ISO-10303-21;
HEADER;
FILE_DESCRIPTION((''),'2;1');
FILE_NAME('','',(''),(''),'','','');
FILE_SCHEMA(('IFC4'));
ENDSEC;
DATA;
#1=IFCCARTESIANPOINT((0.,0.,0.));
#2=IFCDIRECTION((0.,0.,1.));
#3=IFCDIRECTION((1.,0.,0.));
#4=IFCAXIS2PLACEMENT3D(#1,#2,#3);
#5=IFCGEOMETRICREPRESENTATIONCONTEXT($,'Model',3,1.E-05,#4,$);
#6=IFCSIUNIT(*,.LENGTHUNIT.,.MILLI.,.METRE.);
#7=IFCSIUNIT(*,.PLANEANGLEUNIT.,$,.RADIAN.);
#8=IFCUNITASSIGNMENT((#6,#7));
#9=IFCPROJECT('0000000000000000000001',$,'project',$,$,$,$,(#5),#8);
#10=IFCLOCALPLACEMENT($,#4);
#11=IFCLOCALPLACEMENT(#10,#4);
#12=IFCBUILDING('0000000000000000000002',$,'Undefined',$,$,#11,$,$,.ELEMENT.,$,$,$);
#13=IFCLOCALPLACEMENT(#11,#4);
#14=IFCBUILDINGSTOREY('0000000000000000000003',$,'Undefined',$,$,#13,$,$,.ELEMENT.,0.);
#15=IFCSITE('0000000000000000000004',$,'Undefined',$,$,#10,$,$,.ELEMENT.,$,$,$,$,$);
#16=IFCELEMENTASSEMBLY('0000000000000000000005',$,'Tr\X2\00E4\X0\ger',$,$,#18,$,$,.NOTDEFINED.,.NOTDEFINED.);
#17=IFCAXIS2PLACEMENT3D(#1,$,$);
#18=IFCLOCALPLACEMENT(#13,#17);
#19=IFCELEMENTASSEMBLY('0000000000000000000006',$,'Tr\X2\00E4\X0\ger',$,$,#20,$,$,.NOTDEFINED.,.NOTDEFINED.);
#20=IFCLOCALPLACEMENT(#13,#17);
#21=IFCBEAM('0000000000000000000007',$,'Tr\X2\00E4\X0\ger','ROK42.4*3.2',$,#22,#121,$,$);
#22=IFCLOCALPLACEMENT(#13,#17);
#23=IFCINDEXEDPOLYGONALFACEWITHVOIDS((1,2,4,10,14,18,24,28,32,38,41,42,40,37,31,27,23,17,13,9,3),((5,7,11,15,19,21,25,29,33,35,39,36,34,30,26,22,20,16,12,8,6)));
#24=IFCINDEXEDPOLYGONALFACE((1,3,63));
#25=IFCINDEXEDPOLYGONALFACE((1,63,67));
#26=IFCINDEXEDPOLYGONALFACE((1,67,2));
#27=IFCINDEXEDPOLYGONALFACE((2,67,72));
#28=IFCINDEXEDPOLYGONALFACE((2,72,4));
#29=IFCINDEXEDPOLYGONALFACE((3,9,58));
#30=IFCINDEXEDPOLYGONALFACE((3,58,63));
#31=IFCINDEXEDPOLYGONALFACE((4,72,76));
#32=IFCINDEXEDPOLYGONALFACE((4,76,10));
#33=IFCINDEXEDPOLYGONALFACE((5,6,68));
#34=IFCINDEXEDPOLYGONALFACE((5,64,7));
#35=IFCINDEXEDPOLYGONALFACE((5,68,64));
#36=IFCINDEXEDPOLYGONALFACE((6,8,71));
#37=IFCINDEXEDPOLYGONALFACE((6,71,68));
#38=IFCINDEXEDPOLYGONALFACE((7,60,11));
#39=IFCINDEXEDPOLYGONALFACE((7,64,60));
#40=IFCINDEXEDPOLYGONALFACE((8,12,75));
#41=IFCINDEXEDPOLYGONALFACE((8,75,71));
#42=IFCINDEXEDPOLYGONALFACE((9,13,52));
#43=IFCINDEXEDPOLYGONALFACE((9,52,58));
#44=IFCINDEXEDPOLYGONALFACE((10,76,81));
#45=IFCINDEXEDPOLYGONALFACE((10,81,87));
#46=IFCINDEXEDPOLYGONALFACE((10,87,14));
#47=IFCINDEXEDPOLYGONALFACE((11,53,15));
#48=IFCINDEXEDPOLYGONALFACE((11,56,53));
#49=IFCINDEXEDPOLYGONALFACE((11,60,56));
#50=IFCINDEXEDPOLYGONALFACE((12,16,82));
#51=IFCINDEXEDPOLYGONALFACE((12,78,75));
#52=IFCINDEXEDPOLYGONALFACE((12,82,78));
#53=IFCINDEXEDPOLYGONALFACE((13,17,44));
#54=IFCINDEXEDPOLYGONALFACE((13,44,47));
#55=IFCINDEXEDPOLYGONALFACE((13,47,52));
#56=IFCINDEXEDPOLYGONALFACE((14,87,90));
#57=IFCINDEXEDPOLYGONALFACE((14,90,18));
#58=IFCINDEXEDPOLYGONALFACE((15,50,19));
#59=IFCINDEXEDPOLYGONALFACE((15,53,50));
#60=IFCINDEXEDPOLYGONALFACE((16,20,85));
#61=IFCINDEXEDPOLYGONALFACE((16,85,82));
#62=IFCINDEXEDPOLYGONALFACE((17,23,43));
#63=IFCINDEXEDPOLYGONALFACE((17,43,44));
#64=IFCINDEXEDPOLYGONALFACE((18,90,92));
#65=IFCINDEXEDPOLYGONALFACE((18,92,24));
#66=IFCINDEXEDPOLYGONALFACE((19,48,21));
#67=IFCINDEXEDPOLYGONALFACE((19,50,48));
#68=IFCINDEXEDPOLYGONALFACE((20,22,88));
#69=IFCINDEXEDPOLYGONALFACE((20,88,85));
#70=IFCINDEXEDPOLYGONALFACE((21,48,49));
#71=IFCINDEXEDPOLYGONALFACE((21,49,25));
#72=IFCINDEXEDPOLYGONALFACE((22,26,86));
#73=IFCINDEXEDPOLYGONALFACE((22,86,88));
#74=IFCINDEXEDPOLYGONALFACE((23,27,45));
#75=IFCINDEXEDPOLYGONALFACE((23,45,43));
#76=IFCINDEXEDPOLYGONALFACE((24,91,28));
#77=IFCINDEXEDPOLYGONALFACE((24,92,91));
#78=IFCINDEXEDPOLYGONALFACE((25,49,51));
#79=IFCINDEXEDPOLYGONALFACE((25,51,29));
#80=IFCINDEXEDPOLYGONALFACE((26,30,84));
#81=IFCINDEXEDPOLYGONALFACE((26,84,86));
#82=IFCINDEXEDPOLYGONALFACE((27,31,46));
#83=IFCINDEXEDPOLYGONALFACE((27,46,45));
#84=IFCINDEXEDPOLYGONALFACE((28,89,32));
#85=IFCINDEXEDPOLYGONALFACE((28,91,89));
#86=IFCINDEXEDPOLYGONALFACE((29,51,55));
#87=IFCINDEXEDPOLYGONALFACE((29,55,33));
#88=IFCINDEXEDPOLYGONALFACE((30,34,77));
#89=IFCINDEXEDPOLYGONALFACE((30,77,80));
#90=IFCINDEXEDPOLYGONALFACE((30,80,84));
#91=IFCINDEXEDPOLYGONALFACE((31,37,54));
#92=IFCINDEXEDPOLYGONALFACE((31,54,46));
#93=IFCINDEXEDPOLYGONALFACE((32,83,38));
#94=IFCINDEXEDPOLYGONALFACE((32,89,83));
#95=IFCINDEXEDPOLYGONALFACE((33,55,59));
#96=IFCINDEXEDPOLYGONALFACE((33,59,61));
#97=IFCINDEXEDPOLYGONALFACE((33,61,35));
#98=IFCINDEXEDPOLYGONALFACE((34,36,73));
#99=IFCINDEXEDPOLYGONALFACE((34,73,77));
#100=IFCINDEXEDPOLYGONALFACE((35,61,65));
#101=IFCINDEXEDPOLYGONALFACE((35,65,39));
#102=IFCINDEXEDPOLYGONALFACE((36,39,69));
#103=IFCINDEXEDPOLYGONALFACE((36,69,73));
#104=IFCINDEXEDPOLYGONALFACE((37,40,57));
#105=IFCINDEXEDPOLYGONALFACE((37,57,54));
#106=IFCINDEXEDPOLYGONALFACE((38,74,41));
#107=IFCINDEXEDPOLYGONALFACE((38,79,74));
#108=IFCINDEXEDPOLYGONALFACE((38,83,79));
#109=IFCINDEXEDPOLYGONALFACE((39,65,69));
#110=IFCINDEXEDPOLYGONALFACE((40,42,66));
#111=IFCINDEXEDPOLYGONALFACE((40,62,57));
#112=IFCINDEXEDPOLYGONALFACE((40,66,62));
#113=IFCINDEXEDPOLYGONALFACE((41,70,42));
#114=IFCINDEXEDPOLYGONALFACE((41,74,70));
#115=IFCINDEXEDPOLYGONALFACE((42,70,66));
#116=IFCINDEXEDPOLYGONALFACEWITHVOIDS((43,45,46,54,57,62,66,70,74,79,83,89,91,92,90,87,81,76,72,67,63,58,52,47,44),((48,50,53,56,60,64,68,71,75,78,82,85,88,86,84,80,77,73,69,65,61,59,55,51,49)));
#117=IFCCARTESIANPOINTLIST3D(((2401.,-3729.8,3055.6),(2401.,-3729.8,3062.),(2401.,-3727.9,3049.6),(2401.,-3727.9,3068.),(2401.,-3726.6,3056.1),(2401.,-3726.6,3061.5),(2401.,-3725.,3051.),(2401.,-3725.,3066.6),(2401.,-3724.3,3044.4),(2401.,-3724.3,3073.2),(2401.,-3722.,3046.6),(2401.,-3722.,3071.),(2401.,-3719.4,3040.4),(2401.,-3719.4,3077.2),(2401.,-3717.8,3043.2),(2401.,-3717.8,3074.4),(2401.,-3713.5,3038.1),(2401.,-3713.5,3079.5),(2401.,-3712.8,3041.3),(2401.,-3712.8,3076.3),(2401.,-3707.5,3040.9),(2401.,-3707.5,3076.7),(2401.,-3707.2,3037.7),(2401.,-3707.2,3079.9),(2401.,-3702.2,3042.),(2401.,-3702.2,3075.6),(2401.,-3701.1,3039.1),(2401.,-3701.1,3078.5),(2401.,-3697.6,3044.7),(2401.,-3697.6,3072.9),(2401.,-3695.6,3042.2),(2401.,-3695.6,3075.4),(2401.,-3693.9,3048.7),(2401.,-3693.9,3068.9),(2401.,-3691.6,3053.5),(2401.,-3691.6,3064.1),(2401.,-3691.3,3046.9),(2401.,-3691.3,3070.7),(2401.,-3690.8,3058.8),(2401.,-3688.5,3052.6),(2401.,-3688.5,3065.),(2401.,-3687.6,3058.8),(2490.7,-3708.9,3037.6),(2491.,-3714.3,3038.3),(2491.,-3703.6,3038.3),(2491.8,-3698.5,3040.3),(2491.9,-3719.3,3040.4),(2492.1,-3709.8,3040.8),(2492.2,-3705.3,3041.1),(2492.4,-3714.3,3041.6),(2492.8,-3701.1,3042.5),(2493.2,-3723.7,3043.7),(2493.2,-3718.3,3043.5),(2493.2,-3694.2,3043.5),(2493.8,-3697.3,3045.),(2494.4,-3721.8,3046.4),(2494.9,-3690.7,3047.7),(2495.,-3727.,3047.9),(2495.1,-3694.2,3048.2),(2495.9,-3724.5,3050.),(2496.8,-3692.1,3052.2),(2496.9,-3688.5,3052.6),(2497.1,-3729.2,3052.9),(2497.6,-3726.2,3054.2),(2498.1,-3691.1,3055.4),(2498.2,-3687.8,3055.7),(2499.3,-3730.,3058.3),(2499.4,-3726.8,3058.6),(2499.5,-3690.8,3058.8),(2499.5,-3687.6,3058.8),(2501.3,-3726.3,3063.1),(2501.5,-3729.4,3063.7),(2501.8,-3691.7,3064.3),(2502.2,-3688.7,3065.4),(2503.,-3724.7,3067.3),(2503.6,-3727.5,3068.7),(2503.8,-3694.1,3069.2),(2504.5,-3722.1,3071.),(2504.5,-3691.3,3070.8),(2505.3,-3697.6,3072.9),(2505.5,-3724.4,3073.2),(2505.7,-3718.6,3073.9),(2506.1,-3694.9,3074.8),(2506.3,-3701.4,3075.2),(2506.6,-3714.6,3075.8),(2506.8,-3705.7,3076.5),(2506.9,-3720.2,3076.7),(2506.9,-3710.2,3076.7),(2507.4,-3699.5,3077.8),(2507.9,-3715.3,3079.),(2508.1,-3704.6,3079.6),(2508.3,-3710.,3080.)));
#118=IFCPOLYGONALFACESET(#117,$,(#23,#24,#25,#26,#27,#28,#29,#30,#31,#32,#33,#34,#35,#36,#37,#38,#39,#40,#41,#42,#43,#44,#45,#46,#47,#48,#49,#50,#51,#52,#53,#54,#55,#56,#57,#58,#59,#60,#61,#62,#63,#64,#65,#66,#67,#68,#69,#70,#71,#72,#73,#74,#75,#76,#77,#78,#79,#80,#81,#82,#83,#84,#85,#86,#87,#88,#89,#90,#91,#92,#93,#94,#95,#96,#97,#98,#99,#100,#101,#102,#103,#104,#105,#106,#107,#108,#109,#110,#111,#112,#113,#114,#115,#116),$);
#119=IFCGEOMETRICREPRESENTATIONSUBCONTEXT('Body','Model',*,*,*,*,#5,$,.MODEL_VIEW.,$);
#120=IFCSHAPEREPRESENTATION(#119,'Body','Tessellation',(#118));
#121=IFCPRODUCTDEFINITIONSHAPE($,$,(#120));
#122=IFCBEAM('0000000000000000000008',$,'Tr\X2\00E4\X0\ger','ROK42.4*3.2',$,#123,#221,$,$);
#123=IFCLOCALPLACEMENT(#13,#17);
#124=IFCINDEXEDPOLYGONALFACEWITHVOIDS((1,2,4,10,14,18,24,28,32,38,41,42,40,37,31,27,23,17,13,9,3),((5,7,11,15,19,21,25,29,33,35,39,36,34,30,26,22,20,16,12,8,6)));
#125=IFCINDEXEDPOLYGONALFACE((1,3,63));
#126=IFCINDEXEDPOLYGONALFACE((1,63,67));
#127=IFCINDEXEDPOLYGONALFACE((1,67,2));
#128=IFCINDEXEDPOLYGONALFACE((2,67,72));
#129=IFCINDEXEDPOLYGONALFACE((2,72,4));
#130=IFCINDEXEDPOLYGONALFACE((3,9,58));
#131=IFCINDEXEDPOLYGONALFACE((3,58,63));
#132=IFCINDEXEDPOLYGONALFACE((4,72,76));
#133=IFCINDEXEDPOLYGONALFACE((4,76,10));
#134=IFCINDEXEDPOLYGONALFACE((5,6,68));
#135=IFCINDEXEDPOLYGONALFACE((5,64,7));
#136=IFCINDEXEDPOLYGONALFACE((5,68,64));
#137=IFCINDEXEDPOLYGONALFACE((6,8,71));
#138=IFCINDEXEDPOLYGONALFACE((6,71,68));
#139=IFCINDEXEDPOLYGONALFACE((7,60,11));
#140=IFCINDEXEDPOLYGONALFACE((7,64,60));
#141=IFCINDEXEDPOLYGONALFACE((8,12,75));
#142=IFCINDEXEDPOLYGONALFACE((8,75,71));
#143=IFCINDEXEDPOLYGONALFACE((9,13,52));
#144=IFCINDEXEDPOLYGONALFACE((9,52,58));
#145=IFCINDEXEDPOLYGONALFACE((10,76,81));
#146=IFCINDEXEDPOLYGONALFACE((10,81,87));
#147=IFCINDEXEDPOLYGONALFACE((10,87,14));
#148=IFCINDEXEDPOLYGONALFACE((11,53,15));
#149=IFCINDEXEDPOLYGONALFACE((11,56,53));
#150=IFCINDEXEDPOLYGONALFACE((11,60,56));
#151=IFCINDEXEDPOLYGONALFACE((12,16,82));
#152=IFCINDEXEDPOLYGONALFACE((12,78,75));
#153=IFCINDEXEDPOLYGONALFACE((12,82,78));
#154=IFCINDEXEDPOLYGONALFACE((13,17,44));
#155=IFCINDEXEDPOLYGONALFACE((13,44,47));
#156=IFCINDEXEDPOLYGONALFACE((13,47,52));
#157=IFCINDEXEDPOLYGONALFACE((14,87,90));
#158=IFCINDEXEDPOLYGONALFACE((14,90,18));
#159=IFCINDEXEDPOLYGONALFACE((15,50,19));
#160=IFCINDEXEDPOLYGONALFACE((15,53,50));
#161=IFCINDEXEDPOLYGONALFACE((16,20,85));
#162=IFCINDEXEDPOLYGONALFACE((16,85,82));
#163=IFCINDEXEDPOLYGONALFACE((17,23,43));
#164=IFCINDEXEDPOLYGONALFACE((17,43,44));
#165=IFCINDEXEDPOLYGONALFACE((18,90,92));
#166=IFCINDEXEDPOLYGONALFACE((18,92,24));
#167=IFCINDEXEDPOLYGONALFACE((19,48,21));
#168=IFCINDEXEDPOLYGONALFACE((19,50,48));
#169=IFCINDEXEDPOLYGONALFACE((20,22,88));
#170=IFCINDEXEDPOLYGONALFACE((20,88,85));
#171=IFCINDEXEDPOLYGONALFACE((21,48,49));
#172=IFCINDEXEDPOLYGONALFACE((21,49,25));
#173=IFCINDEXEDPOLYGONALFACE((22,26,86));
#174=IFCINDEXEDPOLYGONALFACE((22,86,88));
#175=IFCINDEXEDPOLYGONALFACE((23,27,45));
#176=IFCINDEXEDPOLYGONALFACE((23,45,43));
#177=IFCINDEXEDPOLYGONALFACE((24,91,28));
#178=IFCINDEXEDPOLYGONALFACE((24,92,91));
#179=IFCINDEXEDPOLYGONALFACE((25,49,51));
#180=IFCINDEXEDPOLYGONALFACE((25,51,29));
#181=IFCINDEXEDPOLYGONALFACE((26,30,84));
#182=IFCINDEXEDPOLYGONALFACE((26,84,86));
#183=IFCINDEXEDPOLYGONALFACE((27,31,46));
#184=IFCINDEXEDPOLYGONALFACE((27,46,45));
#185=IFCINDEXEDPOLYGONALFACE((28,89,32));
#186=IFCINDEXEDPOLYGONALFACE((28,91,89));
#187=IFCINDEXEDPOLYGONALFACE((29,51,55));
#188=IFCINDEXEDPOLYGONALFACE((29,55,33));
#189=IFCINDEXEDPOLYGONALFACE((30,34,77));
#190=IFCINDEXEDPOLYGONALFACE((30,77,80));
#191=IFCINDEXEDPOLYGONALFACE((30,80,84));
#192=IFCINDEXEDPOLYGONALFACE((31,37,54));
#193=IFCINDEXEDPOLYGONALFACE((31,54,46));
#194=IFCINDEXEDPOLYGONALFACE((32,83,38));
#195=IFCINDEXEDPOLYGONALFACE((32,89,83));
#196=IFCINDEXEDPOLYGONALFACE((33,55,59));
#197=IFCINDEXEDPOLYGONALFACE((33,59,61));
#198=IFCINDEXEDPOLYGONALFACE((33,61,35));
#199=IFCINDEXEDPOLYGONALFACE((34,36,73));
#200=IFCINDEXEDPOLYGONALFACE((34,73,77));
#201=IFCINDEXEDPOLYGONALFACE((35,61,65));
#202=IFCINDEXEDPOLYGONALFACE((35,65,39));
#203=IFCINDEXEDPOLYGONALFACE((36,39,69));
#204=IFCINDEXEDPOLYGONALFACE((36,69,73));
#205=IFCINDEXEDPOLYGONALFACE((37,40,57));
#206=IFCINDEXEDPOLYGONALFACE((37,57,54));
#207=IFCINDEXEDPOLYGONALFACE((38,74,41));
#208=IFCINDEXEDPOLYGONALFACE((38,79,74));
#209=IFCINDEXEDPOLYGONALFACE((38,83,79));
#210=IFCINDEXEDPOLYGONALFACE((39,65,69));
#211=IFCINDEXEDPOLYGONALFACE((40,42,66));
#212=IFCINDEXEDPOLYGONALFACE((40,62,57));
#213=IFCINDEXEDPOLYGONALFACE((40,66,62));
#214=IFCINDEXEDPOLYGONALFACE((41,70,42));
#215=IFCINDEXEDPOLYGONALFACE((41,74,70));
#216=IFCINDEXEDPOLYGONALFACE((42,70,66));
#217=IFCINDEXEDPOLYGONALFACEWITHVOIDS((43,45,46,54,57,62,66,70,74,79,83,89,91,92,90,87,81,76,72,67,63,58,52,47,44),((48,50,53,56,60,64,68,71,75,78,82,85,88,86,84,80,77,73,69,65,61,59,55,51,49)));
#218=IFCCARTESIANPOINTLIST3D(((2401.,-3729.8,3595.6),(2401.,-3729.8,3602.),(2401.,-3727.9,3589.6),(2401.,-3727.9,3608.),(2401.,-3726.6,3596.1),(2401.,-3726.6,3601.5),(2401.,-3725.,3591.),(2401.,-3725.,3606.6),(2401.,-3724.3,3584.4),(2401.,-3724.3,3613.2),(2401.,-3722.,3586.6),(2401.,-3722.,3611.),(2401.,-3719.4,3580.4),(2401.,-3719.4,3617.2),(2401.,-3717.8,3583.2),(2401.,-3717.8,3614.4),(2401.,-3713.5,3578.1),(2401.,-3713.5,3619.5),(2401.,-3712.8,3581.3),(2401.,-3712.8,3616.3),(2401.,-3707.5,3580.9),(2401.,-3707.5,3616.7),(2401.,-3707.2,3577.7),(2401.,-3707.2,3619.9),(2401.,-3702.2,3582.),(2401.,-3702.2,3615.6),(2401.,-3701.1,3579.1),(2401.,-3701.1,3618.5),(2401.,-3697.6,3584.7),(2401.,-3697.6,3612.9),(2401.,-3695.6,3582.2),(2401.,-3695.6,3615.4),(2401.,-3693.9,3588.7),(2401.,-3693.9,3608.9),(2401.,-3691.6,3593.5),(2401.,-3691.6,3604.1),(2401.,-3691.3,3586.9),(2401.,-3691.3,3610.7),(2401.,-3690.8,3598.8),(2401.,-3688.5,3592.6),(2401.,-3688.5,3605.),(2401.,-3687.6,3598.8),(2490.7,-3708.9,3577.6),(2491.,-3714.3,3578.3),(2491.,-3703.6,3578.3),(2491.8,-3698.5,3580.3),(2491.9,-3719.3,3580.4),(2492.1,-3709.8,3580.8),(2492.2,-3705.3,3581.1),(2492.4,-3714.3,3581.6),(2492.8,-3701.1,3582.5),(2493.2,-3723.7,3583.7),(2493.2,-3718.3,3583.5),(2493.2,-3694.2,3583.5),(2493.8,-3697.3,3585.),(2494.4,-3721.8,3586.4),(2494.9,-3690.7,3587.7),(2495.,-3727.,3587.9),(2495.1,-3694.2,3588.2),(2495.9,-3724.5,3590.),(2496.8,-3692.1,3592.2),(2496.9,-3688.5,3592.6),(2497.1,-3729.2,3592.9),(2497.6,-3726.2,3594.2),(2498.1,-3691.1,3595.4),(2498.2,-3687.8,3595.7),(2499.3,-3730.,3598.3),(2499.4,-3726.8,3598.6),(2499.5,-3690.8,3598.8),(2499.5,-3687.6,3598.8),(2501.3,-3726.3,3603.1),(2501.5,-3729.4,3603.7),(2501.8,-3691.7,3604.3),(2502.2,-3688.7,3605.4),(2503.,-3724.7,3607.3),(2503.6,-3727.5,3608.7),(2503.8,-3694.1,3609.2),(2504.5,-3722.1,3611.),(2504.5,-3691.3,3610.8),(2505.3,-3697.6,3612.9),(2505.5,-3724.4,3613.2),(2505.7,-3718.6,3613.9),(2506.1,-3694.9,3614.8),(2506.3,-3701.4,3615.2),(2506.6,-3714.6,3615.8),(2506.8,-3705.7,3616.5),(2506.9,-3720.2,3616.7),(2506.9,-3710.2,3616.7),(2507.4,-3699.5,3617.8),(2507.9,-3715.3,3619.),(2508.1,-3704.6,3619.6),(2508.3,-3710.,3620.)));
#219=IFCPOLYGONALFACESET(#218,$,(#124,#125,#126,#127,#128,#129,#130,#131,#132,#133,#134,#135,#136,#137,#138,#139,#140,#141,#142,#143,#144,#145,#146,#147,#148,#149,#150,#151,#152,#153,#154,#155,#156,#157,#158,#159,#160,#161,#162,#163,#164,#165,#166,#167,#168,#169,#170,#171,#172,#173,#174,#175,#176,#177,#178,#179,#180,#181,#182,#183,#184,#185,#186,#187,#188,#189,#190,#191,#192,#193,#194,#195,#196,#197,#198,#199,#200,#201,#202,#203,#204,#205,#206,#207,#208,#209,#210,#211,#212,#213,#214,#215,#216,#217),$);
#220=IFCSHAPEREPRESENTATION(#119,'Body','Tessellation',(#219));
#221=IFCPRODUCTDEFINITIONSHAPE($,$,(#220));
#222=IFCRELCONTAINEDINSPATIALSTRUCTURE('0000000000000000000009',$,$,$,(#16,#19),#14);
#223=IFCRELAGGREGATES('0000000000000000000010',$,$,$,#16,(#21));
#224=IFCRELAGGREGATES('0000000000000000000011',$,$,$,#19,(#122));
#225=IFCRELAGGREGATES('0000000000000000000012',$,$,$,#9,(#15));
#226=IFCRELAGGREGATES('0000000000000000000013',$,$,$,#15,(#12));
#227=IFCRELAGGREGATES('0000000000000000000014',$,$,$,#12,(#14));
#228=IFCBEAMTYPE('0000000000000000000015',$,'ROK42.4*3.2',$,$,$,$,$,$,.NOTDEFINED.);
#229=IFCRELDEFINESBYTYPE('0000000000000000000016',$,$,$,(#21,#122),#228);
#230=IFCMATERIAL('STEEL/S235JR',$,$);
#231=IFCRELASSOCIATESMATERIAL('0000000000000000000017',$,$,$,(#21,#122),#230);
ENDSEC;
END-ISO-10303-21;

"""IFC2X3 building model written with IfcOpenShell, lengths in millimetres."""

from ifc_helpers import new_model, si_unit, frame, origin_with_axes, origin_2d_with_axis, place, context, subcontext, project, spatial, hollow_circle, extrude, clip, halfspace, material, type_object, element, aggregate, save


model = new_model("IFC2X3")

# Units and contexts
model_context = context("Model", 3, precision=1e-05, world=origin_with_axes())
body_context = subcontext(model_context, "Body", "Model", "MODEL_VIEW")
ifc_project = project(units=[si_unit("LENGTHUNIT", "METRE", prefix="MILLI"), si_unit("PLANEANGLEUNIT", "RADIAN")], contexts=[model_context])

# Site, building, storey
site_placement = place(None, origin_with_axes())
site = spatial("IfcSite", under=ifc_project, at=site_placement, Name="Undefined", CompositionType="ELEMENT")
building_placement = place(site_placement, origin_with_axes())
building = spatial("IfcBuilding", under=site, at=building_placement, Name="Undefined", CompositionType="ELEMENT")
storey_placement = place(building_placement, origin_with_axes())
storey = spatial("IfcBuildingStorey", under=building, at=storey_placement, Name="Undefined", CompositionType="ELEMENT", Elevation=0.0)

# Shared definitions
ifc_material_1 = material(Name="STEEL/S235JR")
beam_type = type_object("IfcBeamType", Name="ROK42.4*3.2", PredefinedType="NOTDEFINED")

# Element assemblies
assembly_1_placement = place(storey_placement, origin_with_axes())
assembly_1 = element("IfcElementAssembly", 1, at=assembly_1_placement, inside=storey, Name="Träger", AssemblyPlace="NOTDEFINED", PredefinedType="NOTDEFINED")
assembly_2_placement = place(storey_placement, origin_with_axes())
assembly_2 = element("IfcElementAssembly", 2, at=assembly_2_placement, inside=storey, Name="Träger", AssemblyPlace="NOTDEFINED", PredefinedType="NOTDEFINED")

# Beams
beam_1_placement = place(assembly_1_placement, frame((2500.0, -3708.8, 3058.8), z_axis=(0.0, 0.0, 1.0), x_axis=(-1.0, 0.0, 0.0)))
beam_1 = element("IfcBeam", 3, at=beam_1_placement, type_object=beam_type, material=ifc_material_1, Name="Träger", Description="ROK42.4*3.2", context=body_context, shape_type="Clipping", body=[
    clip(extrude(hollow_circle(Radius=21.2, WallThickness=3.2, at=origin_2d_with_axis()), frame((99.0, 0.0, 0.0), z_axis=(-1.0, 0.0, 0.0), x_axis=(0.0, -1.0, 0.0)), (0.0, 0.0, 1.0), 107.4), halfspace(frame((-8.3, 0.0, 21.2), z_axis=(-0.923878, 0.0, -0.382686), x_axis=(0.0, -1.0, 0.0)), False)),
])
beam_2_placement = place(assembly_2_placement, frame((2500.0, -3708.8, 3598.8), z_axis=(0.0, 0.0, 1.0), x_axis=(-1.0, 0.0, 0.0)))
beam_2 = element("IfcBeam", 4, at=beam_2_placement, type_object=beam_type, material=ifc_material_1, Name="Träger", Description="ROK42.4*3.2", context=body_context, shape_type="Clipping", body=[
    clip(extrude(hollow_circle(Radius=21.2, WallThickness=3.2, at=origin_2d_with_axis()), frame((99.0, 0.0, 0.0), z_axis=(-1.0, 0.0, 0.0), x_axis=(0.0, -1.0, 0.0)), (0.0, 0.0, 1.0), 107.4), halfspace(frame((-8.3, 0.0, 21.2), z_axis=(-0.923878, 0.0, -0.382686), x_axis=(0.0, -1.0, 0.0)), False)),
])

aggregate(assembly_1, [beam_1])
aggregate(assembly_2, [beam_2])

save(model, "model.ifc")
